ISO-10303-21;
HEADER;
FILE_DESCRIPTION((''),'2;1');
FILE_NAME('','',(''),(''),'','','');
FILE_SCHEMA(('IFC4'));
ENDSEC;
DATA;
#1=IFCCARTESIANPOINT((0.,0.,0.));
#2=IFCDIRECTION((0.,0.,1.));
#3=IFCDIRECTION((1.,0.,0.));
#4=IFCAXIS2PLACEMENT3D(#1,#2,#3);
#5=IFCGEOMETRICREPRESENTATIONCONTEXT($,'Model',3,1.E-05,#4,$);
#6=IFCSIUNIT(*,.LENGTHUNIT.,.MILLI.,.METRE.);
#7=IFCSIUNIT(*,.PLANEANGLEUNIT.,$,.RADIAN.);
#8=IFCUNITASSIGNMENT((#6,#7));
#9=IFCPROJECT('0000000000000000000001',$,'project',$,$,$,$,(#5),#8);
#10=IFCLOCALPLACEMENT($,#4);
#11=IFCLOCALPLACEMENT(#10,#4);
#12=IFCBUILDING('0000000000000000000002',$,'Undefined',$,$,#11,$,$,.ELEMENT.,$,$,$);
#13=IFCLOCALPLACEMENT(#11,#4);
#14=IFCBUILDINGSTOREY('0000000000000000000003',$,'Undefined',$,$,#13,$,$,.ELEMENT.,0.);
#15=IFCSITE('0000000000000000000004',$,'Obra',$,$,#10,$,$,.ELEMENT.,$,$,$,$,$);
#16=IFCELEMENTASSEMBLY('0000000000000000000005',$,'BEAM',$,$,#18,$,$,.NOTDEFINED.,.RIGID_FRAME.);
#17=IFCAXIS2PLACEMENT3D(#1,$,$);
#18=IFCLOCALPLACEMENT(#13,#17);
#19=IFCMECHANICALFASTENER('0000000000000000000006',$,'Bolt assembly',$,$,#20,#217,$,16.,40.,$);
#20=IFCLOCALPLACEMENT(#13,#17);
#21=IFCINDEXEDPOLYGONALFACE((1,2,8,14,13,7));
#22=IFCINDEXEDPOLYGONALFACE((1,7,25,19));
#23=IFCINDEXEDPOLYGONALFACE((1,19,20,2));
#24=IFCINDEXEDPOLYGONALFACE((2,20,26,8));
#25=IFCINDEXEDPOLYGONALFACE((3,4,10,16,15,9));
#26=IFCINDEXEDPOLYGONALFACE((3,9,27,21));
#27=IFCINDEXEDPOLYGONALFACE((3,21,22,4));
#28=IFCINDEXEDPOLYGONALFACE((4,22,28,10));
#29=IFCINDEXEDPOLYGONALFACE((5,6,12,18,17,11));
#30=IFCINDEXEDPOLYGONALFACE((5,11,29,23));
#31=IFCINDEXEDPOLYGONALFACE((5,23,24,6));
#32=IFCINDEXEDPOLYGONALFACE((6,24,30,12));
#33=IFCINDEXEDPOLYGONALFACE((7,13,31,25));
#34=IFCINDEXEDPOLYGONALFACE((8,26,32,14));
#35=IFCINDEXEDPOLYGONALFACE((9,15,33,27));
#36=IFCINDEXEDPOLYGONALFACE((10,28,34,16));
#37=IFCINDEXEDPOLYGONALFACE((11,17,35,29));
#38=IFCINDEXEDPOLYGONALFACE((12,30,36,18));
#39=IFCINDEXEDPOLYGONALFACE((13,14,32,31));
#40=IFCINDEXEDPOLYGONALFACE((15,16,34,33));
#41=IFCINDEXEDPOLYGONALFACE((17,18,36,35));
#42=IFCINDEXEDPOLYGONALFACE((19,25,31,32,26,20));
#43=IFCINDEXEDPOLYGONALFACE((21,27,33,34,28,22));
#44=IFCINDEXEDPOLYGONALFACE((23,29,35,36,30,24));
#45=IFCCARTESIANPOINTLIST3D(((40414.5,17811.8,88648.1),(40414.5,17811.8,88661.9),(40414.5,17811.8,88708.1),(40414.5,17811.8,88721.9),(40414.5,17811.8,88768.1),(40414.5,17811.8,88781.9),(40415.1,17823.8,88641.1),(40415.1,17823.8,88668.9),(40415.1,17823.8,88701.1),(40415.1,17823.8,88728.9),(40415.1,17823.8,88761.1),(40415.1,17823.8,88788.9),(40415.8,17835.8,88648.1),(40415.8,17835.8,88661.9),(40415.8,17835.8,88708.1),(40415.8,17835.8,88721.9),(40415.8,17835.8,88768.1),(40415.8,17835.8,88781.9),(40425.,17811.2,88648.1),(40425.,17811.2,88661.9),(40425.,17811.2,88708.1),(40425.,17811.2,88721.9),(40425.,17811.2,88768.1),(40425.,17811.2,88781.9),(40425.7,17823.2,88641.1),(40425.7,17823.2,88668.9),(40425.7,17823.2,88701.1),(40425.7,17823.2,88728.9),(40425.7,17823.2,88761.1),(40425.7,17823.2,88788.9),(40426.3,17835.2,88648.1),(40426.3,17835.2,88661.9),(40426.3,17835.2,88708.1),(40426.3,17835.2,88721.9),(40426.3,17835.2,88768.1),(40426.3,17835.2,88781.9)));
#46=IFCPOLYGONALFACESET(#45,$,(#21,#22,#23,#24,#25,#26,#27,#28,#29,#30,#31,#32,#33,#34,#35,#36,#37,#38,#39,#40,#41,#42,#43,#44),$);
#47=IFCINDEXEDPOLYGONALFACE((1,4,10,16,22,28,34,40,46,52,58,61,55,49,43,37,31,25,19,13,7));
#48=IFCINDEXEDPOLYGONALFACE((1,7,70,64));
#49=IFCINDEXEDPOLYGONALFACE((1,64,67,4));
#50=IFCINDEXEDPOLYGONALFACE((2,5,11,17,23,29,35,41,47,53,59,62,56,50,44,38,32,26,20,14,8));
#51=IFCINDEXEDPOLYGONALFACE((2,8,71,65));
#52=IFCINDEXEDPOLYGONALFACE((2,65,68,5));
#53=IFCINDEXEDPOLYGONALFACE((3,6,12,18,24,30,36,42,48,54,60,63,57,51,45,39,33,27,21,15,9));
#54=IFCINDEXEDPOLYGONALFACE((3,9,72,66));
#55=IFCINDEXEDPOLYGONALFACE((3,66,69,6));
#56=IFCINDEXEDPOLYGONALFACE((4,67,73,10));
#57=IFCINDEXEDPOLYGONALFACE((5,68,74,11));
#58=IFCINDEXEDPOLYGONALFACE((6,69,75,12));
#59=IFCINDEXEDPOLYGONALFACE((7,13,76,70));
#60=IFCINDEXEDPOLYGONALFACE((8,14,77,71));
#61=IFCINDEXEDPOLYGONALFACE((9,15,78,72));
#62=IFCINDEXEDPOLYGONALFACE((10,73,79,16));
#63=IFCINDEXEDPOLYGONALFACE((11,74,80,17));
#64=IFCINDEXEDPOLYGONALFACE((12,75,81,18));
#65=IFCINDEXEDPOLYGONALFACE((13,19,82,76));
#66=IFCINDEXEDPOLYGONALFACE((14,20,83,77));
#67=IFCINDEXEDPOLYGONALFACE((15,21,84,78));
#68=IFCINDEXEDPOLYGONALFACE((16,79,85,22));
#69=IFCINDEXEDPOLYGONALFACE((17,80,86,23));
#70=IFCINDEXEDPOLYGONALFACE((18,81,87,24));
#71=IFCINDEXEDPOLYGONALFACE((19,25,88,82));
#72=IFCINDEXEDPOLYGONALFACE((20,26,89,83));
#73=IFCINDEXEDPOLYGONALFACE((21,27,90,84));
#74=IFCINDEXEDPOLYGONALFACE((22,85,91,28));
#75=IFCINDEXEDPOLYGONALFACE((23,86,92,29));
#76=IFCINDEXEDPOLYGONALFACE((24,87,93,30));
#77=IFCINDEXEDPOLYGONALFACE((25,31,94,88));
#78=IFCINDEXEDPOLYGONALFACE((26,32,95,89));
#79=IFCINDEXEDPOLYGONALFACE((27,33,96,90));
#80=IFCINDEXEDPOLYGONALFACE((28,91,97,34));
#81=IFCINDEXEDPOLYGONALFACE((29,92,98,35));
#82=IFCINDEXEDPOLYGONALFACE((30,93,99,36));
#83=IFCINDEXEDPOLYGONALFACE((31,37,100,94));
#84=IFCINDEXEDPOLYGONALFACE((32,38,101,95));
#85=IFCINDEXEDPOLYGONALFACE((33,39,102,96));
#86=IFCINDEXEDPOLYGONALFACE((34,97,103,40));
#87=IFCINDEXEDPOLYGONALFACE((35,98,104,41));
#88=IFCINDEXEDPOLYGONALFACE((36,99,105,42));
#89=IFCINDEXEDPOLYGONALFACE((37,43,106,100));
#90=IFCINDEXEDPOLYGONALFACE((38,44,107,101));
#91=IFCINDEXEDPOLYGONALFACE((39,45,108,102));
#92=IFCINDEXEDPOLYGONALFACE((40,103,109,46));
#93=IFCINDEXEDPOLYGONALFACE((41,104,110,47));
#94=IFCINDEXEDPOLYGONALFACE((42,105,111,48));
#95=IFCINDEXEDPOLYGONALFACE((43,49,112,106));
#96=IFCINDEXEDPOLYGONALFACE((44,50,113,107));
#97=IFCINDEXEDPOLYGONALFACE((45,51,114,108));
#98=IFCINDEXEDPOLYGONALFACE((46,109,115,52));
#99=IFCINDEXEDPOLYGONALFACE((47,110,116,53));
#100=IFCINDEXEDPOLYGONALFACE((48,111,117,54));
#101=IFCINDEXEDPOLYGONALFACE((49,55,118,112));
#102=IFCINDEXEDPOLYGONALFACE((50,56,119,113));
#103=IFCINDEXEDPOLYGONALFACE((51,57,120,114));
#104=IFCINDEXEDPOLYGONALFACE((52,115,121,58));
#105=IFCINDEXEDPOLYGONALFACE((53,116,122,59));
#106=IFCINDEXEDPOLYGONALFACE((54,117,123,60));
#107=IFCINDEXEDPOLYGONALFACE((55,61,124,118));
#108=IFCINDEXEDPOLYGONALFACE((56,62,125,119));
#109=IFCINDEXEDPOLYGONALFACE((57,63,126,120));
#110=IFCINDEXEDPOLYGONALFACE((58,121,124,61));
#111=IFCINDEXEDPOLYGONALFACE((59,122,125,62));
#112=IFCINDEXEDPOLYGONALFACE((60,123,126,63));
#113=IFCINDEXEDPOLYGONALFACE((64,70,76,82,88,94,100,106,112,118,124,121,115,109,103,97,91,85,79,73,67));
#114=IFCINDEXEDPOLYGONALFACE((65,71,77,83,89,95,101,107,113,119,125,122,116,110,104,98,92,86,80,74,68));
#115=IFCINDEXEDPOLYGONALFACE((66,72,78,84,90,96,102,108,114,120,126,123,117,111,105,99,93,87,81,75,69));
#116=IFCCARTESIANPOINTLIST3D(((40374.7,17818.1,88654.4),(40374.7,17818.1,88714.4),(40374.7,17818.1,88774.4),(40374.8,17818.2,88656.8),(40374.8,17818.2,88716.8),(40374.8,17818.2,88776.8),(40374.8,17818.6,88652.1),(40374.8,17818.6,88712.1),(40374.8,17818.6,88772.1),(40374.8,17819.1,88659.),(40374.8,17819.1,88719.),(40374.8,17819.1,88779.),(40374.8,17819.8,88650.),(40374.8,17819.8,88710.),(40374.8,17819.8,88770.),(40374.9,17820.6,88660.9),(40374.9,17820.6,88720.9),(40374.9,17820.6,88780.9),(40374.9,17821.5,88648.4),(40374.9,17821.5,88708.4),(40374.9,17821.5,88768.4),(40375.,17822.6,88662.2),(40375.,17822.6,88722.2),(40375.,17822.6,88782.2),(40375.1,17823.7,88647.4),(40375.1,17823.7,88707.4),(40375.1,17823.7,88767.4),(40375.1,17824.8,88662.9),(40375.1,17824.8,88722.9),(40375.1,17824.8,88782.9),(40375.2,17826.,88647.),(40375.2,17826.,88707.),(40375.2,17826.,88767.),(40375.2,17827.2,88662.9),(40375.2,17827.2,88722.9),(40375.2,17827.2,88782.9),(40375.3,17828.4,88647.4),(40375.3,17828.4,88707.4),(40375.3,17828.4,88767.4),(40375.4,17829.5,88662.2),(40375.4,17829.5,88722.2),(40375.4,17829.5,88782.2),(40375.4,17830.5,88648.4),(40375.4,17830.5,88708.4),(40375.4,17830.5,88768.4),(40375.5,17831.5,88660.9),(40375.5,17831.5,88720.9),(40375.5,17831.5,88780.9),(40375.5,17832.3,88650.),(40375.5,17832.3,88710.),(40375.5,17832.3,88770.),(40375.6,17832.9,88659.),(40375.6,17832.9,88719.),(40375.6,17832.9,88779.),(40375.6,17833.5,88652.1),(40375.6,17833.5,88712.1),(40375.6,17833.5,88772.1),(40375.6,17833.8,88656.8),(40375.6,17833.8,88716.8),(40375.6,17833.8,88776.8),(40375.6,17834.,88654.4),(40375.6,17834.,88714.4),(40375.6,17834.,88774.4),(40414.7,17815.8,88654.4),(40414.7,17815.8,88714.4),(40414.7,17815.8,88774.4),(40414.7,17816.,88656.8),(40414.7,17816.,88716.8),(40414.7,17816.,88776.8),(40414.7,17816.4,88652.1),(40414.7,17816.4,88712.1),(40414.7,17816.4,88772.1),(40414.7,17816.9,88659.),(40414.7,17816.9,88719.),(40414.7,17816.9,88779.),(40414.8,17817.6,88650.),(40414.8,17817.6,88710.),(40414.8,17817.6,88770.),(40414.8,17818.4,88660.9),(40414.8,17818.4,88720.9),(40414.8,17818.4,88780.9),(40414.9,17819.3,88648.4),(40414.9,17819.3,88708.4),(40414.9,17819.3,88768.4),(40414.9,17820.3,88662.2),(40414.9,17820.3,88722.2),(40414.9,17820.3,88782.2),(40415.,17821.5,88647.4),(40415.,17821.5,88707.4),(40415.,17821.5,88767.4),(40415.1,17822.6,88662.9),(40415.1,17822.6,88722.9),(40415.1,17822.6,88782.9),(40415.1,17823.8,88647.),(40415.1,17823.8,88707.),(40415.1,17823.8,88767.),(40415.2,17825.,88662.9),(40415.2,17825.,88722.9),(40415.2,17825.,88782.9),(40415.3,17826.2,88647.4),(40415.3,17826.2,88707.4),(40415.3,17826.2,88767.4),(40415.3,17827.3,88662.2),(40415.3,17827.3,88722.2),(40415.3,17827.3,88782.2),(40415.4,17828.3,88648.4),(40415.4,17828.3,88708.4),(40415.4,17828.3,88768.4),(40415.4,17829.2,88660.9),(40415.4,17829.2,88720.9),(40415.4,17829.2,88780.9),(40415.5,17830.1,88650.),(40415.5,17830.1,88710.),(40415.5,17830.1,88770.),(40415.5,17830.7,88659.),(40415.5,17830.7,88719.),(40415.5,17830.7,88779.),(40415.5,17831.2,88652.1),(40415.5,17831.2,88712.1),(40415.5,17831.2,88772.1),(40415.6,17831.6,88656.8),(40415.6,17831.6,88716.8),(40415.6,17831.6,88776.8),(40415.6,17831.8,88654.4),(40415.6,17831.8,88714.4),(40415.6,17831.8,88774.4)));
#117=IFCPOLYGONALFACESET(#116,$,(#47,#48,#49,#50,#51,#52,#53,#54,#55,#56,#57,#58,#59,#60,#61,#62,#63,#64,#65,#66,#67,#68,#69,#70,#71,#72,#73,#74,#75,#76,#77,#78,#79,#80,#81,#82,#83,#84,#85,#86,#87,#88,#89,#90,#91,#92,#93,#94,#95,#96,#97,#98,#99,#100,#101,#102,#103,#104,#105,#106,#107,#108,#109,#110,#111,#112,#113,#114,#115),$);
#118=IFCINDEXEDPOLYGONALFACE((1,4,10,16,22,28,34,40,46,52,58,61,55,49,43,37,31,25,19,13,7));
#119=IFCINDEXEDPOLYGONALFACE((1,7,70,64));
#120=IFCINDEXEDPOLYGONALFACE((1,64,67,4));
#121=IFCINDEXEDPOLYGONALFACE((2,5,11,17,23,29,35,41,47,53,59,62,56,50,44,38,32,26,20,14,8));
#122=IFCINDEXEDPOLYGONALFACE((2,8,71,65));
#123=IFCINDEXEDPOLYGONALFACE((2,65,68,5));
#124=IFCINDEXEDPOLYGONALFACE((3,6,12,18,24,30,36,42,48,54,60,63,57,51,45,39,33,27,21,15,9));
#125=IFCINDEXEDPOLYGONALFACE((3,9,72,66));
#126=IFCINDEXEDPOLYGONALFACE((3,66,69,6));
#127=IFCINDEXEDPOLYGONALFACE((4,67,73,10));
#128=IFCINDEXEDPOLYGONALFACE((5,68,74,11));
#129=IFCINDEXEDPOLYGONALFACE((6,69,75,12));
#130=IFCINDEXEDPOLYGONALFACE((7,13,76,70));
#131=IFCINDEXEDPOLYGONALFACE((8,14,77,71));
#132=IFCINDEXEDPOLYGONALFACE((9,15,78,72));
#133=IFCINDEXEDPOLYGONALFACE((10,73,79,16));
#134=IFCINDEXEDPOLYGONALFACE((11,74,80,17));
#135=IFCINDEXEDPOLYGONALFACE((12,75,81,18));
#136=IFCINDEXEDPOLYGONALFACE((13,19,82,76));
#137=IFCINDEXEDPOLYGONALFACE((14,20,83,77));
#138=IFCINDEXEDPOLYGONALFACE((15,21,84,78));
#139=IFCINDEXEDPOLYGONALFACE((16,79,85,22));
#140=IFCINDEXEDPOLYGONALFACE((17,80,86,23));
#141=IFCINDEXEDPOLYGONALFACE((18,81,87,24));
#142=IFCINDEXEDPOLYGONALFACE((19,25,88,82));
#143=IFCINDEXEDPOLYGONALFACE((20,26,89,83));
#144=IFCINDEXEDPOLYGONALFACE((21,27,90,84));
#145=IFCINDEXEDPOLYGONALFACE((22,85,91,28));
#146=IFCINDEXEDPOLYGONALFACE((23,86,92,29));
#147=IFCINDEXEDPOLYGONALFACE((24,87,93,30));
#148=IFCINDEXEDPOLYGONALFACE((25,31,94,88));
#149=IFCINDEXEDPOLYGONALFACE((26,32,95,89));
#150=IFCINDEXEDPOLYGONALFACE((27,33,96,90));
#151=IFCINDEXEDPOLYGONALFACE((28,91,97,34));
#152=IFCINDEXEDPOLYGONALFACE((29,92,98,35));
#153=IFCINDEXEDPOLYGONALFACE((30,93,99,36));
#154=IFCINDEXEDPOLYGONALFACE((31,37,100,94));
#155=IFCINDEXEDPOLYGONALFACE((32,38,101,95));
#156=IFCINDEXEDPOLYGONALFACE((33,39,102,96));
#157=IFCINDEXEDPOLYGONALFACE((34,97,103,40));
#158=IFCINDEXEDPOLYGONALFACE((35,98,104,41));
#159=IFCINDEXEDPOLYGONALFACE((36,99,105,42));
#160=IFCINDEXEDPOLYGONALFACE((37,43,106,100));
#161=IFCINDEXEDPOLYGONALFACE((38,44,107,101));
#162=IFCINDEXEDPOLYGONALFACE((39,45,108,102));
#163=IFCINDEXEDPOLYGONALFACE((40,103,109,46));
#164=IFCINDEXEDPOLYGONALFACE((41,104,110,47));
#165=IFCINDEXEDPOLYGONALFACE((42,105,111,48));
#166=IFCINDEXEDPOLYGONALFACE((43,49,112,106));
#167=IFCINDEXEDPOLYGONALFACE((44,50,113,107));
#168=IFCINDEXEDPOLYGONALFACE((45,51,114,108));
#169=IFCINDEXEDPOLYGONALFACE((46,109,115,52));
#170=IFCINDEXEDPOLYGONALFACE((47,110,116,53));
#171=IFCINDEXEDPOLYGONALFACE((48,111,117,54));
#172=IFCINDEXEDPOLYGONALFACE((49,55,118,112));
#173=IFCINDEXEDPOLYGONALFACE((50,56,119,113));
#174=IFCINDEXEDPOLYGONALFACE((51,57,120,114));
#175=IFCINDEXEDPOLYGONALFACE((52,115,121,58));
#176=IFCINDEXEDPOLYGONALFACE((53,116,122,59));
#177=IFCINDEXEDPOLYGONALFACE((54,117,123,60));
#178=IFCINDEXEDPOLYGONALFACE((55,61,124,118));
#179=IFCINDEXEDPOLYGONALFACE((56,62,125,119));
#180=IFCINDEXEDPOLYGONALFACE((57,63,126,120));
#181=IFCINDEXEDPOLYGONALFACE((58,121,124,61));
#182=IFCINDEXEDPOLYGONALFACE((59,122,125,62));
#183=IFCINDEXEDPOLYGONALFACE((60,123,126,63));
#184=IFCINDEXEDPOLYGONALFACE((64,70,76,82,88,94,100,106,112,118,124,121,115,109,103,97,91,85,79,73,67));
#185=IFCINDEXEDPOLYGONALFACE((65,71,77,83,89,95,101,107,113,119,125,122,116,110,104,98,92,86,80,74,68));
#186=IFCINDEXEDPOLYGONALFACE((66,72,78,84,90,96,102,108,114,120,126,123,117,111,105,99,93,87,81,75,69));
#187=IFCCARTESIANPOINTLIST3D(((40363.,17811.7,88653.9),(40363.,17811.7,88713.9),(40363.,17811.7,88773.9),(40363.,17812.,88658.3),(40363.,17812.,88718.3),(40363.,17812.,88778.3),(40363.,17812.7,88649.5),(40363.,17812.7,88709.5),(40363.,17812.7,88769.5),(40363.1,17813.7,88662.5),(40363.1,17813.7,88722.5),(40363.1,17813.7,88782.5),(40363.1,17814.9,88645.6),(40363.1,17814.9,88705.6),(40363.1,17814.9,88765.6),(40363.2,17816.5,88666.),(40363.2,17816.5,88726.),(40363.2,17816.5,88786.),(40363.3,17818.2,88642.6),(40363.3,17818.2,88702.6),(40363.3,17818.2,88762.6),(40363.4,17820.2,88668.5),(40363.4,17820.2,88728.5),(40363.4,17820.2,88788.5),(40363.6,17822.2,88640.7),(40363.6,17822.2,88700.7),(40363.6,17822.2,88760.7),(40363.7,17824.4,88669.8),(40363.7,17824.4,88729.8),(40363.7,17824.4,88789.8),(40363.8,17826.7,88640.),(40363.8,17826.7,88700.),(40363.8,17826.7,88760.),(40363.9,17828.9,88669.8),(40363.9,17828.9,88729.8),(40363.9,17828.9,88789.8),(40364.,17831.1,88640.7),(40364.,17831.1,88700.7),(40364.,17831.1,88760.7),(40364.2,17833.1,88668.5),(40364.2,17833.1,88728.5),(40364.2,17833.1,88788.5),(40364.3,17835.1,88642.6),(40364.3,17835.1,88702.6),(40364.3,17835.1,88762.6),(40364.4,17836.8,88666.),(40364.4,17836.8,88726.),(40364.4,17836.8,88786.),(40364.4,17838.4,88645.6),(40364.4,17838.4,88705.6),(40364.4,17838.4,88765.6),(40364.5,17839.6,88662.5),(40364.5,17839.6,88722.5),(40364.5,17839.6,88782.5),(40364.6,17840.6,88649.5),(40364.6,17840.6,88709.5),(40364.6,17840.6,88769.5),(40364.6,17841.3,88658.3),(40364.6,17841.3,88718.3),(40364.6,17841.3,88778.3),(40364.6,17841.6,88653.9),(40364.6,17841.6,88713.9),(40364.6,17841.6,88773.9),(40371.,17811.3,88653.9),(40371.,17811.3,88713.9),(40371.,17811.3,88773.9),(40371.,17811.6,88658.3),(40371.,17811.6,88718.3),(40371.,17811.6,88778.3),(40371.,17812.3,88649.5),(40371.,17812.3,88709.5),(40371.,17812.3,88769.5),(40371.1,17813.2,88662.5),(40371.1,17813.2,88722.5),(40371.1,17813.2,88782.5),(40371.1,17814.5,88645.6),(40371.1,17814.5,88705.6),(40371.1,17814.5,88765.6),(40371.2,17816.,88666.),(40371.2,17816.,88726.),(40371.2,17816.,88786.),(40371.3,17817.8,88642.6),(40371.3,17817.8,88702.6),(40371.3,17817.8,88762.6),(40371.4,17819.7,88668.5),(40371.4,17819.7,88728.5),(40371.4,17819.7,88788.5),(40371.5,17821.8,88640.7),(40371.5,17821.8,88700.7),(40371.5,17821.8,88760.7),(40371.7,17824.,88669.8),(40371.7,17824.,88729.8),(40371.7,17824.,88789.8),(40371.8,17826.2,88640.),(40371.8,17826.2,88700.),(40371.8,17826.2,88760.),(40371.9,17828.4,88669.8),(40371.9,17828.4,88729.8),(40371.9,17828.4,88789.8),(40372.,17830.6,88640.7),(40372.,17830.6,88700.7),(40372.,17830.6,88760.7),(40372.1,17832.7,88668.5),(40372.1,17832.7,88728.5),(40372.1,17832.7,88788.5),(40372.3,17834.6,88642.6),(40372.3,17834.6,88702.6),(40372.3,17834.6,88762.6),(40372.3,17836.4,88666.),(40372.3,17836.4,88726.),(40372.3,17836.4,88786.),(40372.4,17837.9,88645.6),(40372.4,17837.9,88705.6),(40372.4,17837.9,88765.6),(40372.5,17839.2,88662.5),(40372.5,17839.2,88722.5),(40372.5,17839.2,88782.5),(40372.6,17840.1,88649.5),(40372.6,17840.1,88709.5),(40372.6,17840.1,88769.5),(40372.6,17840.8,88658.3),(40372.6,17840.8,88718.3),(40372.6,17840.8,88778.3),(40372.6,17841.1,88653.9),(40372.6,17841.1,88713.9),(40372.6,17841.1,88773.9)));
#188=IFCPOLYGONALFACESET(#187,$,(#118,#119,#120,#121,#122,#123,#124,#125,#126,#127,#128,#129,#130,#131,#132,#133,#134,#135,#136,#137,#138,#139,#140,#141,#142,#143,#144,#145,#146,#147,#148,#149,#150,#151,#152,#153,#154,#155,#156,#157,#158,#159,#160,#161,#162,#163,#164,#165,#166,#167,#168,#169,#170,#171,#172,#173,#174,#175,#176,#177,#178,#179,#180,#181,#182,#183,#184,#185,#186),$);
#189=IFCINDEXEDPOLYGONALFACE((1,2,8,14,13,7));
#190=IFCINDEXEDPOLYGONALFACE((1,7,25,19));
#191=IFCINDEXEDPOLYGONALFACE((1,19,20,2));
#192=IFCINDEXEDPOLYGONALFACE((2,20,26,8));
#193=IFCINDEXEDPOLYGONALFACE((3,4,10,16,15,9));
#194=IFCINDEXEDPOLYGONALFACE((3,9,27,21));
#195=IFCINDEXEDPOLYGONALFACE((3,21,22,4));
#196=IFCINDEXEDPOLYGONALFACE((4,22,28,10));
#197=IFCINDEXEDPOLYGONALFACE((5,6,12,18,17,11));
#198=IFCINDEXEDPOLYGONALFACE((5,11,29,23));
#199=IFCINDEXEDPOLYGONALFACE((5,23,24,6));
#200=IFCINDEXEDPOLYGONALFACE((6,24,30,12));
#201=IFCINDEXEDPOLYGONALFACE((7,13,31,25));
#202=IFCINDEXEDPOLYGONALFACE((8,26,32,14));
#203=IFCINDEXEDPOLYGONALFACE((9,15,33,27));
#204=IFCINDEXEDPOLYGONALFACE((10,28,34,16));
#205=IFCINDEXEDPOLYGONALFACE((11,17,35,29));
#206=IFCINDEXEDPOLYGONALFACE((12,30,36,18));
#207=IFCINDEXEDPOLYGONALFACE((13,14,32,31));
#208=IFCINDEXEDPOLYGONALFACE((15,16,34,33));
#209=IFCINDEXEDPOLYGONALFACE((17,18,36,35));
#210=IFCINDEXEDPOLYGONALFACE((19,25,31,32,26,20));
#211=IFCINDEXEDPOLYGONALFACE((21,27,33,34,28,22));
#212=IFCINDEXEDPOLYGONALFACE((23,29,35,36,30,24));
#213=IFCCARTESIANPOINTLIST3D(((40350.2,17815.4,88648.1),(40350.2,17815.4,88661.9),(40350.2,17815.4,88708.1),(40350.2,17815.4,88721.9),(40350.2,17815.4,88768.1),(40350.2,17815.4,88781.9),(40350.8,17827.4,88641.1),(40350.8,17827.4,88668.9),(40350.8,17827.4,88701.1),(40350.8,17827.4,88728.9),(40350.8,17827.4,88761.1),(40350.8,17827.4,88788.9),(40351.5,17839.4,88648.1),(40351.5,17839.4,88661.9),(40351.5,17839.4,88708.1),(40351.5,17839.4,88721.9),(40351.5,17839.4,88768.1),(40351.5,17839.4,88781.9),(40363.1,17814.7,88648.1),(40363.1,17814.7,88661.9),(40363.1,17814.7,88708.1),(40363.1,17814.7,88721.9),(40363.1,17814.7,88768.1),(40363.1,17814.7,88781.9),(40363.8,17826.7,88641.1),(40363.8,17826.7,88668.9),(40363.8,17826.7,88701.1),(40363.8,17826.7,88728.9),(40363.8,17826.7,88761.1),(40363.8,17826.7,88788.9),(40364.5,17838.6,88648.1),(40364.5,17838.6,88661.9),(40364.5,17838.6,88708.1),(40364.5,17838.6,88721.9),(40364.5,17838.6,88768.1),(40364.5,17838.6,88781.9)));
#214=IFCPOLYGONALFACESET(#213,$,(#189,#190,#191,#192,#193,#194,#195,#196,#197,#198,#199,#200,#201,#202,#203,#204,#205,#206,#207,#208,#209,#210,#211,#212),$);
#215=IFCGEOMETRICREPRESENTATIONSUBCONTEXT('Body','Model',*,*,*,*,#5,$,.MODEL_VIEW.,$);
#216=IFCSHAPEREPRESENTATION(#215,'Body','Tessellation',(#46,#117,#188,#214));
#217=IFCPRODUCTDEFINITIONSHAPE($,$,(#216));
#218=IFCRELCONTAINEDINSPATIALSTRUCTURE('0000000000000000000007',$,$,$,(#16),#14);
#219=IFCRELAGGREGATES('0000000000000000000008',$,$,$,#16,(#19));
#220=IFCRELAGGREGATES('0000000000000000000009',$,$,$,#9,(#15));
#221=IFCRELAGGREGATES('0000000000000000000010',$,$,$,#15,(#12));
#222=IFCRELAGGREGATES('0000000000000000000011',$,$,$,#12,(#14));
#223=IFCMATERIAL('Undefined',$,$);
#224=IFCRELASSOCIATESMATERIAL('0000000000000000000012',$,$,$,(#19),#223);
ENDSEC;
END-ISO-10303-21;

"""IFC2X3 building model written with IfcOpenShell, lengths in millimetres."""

from ifc_helpers import new_model, si_unit, frame, origin_with_axes, origin_2d_with_axis, place, context, subcontext, project, spatial, polyline, circle, outline, extrude, source, transform, mapped, material, element, aggregate, save


model = new_model("IFC2X3")

# Units and contexts
model_context = context("Model", 3, precision=1e-05, world=origin_with_axes())
body_context = subcontext(model_context, "Body", "Model", "MODEL_VIEW")
ifc_project = project(units=[si_unit("LENGTHUNIT", "METRE", prefix="MILLI"), si_unit("PLANEANGLEUNIT", "RADIAN")], contexts=[model_context])

# Site, building, storey
site_placement = place(None, origin_with_axes())
site = spatial("IfcSite", under=ifc_project, at=site_placement, Name="Obra", CompositionType="ELEMENT")
building_placement = place(site_placement, origin_with_axes())
building = spatial("IfcBuilding", under=site, at=building_placement, Name="Undefined", CompositionType="ELEMENT")
storey_placement = place(building_placement, origin_with_axes())
storey = spatial("IfcBuildingStorey", under=building, at=storey_placement, Name="Undefined", CompositionType="ELEMENT", Elevation=0.0)

# Element assembly, mechanical fastener
ifc_material_1 = material(Name="Undefined")
shared_shape_1 = source(origin_with_axes(), body_context, "Body", "SweptSolid", [
    extrude(outline(polyline([(13.9, 0.0), (6.9, 12.0), (-6.9, 12.0), (-13.9, 0.0), (-6.9, -12.0), (6.9, -12.0), (13.9, 0.0)])), frame((0.0, -19.7, 0.0), z_axis=(0.0, 1.0, 0.0), x_axis=(1.0, 0.0, 0.0)), (0.0, 0.0, 1.0), 10.6),
    extrude(circle(Radius=8.0, at=origin_2d_with_axis()), frame((0.0, -9.1, 0.0), z_axis=(0.0, 1.0, 0.0), x_axis=(1.0, 0.0, 0.0)), (0.0, 0.0, 1.0), 40.0),
    extrude(circle(Radius=15.0, at=origin_2d_with_axis()), frame((0.0, 34.3, 0.0), z_axis=(0.0, 1.0, 0.0), x_axis=(1.0, 0.0, 0.0)), (0.0, 0.0, 1.0), 8.0),
    extrude(outline(polyline([(13.9, 0.0), (6.9, 12.0), (-6.9, 12.0), (-13.9, 0.0), (-6.9, -12.0), (6.9, -12.0), (13.9, 0.0)])), frame((0.0, 42.3, 0.0), z_axis=(0.0, 1.0, 0.0), x_axis=(1.0, 0.0, 0.0)), (0.0, 0.0, 1.0), 13.0),
])
assembly_1_placement = place(storey_placement, origin_with_axes())
assembly_1 = element("IfcElementAssembly", 1, at=assembly_1_placement, inside=storey, Name="BEAM", AssemblyPlace="NOTDEFINED", PredefinedType="RIGID_FRAME")
mechanical_fastener_1_placement = place(assembly_1_placement, frame((40403.3, 17774.4, 88835.0), z_axis=(0.055268, 0.998472, 0.0), x_axis=(0.0, 0.0, -1.0)))
mechanical_fastener_1 = element("IfcMechanicalFastener", 2, at=mechanical_fastener_1_placement, material=ifc_material_1, Name="Bolt assembly", NominalDiameter=16.0, NominalLength=40.0, context=body_context, shape_type="MappedRepresentation", body=[
    mapped(shared_shape_1, transform((60.0, 0.0, 50.0))),
    mapped(shared_shape_1, transform((120.0, 0.0, 50.0))),
    mapped(shared_shape_1, transform((180.0, 0.0, 50.0))),
])

aggregate(assembly_1, [mechanical_fastener_1])

save(model, "model.ifc")
